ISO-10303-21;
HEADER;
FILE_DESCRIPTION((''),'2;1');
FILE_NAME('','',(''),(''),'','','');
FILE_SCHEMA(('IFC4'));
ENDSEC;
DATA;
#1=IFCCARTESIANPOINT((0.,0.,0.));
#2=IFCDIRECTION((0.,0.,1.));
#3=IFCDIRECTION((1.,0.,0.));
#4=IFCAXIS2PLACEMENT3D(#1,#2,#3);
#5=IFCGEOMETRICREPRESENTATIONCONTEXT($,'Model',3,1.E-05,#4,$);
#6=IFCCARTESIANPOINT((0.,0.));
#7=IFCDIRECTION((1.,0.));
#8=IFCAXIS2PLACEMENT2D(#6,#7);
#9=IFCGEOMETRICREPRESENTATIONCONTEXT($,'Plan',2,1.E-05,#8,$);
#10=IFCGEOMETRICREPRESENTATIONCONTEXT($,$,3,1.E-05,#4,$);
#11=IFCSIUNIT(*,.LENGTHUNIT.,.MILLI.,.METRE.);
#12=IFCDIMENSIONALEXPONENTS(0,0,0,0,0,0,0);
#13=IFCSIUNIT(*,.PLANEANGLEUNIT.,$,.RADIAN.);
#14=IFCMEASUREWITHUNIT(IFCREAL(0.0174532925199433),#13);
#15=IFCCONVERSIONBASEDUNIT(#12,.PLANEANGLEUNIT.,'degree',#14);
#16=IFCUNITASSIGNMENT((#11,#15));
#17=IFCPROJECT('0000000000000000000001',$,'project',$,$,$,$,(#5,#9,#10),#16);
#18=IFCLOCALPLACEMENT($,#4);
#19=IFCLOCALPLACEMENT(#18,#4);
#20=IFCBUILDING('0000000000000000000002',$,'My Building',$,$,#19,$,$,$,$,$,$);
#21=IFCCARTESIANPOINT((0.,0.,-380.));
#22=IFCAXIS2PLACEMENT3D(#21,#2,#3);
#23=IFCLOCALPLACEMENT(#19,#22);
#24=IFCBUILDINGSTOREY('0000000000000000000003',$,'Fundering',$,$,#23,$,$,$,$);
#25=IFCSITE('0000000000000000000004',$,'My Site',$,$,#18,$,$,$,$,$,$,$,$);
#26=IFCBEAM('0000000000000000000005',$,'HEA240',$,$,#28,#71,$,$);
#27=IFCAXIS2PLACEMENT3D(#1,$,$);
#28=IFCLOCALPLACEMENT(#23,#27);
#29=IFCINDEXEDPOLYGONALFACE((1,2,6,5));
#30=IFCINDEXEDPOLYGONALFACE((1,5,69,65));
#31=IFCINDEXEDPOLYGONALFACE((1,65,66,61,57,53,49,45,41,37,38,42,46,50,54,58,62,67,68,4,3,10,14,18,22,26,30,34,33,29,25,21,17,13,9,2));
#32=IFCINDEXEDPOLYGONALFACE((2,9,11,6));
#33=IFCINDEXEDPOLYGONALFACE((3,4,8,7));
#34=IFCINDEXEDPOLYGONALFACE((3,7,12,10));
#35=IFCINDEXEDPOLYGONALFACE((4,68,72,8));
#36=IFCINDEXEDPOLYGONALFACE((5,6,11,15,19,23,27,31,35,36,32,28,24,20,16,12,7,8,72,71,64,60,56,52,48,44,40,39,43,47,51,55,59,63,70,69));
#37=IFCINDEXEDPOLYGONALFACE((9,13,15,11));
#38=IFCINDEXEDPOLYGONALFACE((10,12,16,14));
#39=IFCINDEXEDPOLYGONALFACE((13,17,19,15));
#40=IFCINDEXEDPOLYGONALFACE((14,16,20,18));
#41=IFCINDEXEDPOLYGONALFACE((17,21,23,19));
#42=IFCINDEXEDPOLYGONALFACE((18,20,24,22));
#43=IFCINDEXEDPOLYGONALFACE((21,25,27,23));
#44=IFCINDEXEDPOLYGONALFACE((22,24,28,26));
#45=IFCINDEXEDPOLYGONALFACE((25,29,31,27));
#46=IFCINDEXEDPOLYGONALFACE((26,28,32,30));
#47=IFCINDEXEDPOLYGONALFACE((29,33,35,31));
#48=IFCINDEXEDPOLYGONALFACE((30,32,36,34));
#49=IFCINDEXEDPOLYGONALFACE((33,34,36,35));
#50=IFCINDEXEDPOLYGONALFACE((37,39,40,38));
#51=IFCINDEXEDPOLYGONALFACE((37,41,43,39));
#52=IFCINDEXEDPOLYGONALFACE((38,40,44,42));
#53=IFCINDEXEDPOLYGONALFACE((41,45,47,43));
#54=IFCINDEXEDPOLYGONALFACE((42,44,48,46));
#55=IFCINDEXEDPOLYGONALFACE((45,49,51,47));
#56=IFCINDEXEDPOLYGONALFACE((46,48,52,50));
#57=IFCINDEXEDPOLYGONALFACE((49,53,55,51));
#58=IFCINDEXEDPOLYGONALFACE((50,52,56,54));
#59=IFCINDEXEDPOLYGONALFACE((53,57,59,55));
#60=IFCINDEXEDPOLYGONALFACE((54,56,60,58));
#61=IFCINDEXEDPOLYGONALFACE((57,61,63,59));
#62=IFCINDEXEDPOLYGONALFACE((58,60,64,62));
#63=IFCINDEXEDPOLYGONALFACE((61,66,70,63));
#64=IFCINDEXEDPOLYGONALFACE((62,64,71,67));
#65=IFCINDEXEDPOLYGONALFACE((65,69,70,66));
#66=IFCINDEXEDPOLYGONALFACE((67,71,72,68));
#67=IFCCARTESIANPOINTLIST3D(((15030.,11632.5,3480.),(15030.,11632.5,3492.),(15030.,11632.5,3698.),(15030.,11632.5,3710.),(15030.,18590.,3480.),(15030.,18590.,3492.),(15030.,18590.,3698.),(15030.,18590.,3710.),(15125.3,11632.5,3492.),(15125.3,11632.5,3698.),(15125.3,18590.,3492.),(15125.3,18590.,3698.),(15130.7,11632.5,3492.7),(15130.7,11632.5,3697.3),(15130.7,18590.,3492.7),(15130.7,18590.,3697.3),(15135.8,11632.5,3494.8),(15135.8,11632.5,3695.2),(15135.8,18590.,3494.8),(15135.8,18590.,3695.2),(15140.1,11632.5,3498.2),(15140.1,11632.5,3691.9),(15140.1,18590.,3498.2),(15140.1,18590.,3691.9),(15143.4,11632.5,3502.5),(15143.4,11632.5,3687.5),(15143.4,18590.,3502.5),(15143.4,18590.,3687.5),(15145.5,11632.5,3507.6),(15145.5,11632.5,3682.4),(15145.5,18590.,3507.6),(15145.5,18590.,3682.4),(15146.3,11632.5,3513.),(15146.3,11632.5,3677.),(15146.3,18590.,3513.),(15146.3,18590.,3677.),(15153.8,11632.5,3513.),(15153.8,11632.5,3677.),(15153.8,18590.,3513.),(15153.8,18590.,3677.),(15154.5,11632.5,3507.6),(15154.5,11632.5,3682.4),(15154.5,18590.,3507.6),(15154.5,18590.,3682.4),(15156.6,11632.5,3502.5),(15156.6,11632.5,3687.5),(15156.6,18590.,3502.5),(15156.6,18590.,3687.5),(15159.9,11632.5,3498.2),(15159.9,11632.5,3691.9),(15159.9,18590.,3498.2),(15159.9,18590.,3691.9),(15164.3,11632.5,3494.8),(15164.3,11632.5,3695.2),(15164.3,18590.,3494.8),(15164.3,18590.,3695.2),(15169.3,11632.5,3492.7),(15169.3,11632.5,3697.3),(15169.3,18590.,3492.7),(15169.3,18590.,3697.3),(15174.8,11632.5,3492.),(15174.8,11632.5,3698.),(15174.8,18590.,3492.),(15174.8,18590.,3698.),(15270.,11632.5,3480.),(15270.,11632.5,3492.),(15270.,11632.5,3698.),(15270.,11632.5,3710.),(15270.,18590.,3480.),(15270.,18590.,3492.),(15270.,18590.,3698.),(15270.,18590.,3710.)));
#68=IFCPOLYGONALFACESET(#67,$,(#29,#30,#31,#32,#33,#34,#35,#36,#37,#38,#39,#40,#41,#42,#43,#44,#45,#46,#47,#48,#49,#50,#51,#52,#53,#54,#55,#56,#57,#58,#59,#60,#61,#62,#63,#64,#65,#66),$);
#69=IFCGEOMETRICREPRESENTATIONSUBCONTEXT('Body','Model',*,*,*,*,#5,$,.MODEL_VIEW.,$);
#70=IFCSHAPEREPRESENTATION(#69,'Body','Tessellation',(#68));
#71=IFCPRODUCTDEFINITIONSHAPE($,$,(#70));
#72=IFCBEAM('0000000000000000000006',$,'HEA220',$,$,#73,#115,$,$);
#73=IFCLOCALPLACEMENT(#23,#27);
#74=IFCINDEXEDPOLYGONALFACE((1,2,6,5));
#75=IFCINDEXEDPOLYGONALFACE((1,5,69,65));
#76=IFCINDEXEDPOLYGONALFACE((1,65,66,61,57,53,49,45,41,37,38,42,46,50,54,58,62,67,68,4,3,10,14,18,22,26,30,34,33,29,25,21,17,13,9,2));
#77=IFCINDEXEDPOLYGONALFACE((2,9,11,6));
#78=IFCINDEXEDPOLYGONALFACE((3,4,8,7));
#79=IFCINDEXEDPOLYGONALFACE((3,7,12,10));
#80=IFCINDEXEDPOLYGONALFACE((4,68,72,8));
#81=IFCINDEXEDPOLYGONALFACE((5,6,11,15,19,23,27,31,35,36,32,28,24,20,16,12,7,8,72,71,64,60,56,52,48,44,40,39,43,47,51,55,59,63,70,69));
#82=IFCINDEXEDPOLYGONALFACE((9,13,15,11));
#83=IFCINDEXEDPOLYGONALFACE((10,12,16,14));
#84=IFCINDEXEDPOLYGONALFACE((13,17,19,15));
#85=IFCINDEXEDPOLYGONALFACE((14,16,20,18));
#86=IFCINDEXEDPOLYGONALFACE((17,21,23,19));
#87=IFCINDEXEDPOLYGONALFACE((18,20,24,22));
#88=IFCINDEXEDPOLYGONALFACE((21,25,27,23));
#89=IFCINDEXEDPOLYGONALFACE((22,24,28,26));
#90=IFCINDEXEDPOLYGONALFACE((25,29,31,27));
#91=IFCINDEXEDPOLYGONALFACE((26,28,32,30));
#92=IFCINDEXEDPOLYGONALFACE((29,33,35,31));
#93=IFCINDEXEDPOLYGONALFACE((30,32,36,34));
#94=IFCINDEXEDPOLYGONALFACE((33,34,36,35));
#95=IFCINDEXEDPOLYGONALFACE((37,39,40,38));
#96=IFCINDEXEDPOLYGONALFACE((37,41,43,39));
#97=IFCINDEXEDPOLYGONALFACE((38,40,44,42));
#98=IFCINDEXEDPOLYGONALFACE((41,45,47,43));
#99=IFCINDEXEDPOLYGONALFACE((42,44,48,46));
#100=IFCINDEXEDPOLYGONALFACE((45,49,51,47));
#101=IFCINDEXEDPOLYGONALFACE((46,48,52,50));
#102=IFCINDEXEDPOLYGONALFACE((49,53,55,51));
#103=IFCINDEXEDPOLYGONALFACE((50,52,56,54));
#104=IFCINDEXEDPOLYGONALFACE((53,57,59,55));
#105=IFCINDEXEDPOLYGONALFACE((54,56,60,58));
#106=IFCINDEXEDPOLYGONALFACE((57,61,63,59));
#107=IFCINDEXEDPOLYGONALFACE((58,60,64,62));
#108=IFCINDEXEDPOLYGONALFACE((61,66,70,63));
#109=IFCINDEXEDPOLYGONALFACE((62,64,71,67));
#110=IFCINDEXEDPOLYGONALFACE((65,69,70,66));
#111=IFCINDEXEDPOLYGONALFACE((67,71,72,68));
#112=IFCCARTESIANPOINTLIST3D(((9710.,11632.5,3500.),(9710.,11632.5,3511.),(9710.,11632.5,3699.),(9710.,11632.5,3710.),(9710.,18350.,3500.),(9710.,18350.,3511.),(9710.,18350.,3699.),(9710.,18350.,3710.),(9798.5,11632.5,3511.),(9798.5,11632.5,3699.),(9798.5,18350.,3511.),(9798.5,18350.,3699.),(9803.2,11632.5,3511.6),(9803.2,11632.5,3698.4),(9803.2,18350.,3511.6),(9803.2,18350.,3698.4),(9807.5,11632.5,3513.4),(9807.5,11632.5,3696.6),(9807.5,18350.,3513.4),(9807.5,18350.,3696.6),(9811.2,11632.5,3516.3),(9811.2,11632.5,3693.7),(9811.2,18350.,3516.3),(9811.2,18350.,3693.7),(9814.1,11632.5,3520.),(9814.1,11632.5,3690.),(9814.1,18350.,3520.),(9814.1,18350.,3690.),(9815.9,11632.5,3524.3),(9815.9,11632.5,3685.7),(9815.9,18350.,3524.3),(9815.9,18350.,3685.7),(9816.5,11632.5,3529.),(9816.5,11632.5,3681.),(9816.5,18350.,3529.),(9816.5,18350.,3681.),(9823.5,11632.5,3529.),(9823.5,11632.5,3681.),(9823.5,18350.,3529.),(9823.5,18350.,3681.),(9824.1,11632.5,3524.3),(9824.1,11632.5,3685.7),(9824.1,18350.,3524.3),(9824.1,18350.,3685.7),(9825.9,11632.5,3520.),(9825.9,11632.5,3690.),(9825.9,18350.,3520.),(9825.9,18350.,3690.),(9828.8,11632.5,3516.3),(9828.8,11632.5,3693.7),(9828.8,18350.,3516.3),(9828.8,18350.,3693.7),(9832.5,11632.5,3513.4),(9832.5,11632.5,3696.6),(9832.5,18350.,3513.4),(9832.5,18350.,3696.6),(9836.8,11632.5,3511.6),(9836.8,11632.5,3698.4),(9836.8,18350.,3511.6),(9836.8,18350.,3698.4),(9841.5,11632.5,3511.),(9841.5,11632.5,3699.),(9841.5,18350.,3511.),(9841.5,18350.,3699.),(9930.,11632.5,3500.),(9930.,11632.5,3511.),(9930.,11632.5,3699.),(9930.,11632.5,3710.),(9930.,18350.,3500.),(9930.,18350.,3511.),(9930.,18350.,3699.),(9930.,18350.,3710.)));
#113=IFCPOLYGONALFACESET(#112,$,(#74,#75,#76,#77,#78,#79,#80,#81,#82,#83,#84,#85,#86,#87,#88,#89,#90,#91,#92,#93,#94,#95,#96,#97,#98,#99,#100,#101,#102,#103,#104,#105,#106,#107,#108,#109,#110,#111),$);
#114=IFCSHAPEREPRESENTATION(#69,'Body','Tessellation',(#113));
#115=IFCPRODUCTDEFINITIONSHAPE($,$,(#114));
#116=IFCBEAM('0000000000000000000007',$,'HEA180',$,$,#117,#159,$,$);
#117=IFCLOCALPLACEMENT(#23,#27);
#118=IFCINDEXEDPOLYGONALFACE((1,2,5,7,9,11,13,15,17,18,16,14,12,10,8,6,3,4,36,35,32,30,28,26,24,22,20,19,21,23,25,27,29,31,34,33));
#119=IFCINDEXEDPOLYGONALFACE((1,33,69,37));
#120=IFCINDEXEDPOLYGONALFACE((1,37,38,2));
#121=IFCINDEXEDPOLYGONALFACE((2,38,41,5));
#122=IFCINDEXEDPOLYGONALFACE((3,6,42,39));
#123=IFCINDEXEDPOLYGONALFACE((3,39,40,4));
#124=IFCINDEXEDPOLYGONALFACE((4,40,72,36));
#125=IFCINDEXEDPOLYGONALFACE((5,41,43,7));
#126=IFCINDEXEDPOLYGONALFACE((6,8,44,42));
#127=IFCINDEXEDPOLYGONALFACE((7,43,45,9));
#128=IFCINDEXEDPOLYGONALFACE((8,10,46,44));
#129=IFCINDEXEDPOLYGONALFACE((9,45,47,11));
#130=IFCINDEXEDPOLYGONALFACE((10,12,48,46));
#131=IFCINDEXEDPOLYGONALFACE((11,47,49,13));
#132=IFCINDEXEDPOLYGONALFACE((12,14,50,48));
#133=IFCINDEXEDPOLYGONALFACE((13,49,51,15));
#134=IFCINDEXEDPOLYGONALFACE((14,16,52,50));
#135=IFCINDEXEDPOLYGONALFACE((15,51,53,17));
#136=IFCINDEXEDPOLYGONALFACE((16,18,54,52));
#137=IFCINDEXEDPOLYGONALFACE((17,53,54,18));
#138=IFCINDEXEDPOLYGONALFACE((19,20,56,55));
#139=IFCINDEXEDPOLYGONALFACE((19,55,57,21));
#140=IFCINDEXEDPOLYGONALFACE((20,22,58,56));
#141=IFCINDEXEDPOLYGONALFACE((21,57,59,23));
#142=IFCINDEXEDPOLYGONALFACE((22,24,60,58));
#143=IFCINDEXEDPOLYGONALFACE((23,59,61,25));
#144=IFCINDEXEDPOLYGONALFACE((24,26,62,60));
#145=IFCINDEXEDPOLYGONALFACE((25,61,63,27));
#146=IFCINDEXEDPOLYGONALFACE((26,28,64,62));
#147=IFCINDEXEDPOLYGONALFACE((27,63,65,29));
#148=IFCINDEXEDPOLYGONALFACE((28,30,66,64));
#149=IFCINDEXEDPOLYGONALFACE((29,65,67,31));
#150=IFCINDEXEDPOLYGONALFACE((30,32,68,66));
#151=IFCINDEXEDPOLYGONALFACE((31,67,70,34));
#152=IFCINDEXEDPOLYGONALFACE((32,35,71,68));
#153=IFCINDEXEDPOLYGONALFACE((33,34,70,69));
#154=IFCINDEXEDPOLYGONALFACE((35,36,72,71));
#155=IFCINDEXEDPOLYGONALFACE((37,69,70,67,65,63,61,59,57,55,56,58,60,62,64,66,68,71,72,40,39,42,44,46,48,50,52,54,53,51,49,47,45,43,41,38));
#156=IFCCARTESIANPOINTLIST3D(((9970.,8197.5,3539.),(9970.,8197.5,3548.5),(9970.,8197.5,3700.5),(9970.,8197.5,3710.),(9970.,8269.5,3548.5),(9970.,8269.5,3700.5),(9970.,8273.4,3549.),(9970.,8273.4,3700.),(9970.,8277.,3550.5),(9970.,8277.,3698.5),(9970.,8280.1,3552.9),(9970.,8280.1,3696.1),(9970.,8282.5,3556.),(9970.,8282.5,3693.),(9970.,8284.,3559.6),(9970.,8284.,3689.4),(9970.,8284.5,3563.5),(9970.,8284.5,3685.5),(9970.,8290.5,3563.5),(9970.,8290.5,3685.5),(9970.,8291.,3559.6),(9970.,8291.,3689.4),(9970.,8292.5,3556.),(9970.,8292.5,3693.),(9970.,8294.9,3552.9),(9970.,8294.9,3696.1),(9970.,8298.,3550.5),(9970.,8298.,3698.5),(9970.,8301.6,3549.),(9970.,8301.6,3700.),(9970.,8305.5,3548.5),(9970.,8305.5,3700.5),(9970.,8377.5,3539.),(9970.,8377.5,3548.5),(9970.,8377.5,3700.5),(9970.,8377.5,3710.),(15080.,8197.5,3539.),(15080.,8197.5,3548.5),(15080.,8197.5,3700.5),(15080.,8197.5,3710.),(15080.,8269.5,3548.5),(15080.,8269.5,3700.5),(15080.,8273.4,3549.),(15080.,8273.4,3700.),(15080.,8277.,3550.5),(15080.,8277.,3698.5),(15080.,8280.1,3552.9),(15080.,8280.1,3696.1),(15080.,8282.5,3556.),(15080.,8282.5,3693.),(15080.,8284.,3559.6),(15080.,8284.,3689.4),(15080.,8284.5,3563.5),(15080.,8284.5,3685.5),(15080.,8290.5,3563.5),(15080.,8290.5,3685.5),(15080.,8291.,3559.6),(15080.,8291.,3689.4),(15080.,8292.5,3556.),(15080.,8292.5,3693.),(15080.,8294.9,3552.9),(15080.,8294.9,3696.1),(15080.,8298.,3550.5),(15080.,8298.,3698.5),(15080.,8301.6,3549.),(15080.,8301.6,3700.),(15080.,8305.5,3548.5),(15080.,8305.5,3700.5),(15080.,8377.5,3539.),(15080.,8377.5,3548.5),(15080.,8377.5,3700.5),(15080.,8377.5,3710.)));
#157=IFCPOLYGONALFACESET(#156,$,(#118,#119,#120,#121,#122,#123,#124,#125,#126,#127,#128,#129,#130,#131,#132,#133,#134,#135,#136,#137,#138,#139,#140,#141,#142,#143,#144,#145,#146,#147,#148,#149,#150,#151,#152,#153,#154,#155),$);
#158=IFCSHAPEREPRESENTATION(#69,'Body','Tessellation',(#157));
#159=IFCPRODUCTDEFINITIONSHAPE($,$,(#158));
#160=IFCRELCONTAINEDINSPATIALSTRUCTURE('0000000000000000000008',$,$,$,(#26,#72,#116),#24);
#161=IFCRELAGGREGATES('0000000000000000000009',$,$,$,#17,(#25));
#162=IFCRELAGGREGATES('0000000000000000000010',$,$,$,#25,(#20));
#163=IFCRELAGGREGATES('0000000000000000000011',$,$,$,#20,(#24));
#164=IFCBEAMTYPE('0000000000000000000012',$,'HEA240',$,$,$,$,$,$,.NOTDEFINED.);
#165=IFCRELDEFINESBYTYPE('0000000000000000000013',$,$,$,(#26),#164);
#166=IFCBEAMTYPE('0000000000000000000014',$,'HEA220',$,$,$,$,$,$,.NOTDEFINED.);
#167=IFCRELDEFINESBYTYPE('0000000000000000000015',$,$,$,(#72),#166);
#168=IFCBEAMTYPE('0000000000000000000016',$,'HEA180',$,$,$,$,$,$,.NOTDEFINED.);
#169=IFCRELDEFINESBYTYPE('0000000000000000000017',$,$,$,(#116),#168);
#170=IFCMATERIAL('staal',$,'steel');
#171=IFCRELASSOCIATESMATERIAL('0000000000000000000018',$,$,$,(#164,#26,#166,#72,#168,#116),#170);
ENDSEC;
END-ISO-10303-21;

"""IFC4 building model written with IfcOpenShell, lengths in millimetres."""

from ifc_helpers import new_model, entity, si_unit, converted_unit, frame, origin_with_axes, origin_2d_with_axis, place, context, subcontext, project, spatial, i_section, extrude, material, material_profile, profile_set, profile_usage, type_object, element, save


model = new_model("IFC4")

# Units and contexts
model_context = context("Model", 3, precision=1e-05, world=origin_with_axes())
plan_context = context("Plan", 2, precision=1e-05, world=origin_2d_with_axis())
context_of_model = context(None, 3, precision=1e-05, world=origin_with_axes())
body_context = subcontext(model_context, "Body", "Model", "MODEL_VIEW")
ifc_project = project(units=[si_unit("LENGTHUNIT", "METRE", prefix="MILLI"), converted_unit("PLANEANGLEUNIT", "degree", entity("IfcReal", 0.0174532925199433), si_unit("PLANEANGLEUNIT", "RADIAN"), dimensions=[0, 0, 0, 0, 0, 0, 0])], contexts=[model_context, plan_context, context_of_model])

# Site, building, storey
site_placement = place(None, origin_with_axes())
site = spatial("IfcSite", under=ifc_project, at=site_placement, Name="My Site")
building_placement = place(site_placement, origin_with_axes())
building = spatial("IfcBuilding", under=site, at=building_placement, Name="My Building")
storey_placement = place(building_placement, frame((0.0, 0.0, -380.0), z_axis=(0.0, 0.0, 1.0), x_axis=(1.0, 0.0, 0.0)))
storey = spatial("IfcBuildingStorey", under=building, at=storey_placement, Name="Fundering")

# Shared definitions
ifc_material_1 = material(Name="staal", Category="steel")

# Beams
ifc_material_profile_1 = material_profile(ifc_material_1, i_section(OverallWidth=240.0, OverallDepth=230.0, WebThickness=7.5, FlangeThickness=12.0, FilletRadius=21.0))
ifc_profile_set_1 = profile_set([ifc_material_profile_1], Name="HEA240")
ifc_profile_usage_1 = profile_usage(ifc_profile_set_1, cardinal=5)
beam_type_1 = type_object("IfcBeamType", Name="HEA240", PredefinedType="NOTDEFINED", material=ifc_profile_set_1)
beam_1_placement = place(storey_placement, frame((15150.0, 18590.0, 3595.0), z_axis=(0.0, -1.0, 0.0), x_axis=(1.0, 0.0, 0.0)))
element("IfcBeam", 1, at=beam_1_placement, inside=storey, type_object=beam_type_1, material=ifc_profile_usage_1, Name="HEA240", context=body_context, shape_type="SweptSolid", body=[
    extrude(i_section(OverallWidth=240.0, OverallDepth=230.0, WebThickness=7.5, FlangeThickness=12.0, FilletRadius=21.0), origin_with_axes(), (0.0, 0.0, 1.0), 6957.5),
])
ifc_material_profile_2 = material_profile(ifc_material_1, i_section(OverallWidth=220.0, OverallDepth=210.0, WebThickness=7.0, FlangeThickness=11.0, FilletRadius=18.0))
ifc_profile_set_2 = profile_set([ifc_material_profile_2], Name="HEA220")
ifc_profile_usage_2 = profile_usage(ifc_profile_set_2)
beam_type_2 = type_object("IfcBeamType", Name="HEA220", PredefinedType="NOTDEFINED", material=ifc_profile_set_2)
beam_2_placement = place(storey_placement, frame((9820.0, 18350.0, 3605.0), z_axis=(0.0, -1.0, 0.0), x_axis=(1.0, 0.0, 0.0)))
element("IfcBeam", 2, at=beam_2_placement, inside=storey, type_object=beam_type_2, material=ifc_profile_usage_2, Name="HEA220", context=body_context, shape_type="SweptSolid", body=[
    extrude(i_section(OverallWidth=220.0, OverallDepth=210.0, WebThickness=7.0, FlangeThickness=11.0, FilletRadius=18.0), origin_with_axes(), (0.0, 0.0, 1.0), 6717.5),
])
ifc_material_profile_3 = material_profile(ifc_material_1, i_section(OverallWidth=180.0, OverallDepth=171.0, WebThickness=6.0, FlangeThickness=9.5, FilletRadius=15.0))
ifc_profile_set_3 = profile_set([ifc_material_profile_3], Name="HEA180")
ifc_profile_usage_3 = profile_usage(ifc_profile_set_3)
beam_type_3 = type_object("IfcBeamType", Name="HEA180", PredefinedType="NOTDEFINED", material=ifc_profile_set_3)
beam_3_placement = place(storey_placement, frame((9970.0, 8287.5, 3624.5), z_axis=(1.0, 0.0, 0.0), x_axis=(0.0, 1.0, 0.0)))
element("IfcBeam", 3, at=beam_3_placement, inside=storey, type_object=beam_type_3, material=ifc_profile_usage_3, Name="HEA180", context=body_context, shape_type="SweptSolid", body=[
    extrude(i_section(OverallWidth=180.0, OverallDepth=171.0, WebThickness=6.0, FlangeThickness=9.5, FilletRadius=15.0), origin_with_axes(), (0.0, 0.0, 1.0), 5110.0),
])

save(model, "model.ifc")
